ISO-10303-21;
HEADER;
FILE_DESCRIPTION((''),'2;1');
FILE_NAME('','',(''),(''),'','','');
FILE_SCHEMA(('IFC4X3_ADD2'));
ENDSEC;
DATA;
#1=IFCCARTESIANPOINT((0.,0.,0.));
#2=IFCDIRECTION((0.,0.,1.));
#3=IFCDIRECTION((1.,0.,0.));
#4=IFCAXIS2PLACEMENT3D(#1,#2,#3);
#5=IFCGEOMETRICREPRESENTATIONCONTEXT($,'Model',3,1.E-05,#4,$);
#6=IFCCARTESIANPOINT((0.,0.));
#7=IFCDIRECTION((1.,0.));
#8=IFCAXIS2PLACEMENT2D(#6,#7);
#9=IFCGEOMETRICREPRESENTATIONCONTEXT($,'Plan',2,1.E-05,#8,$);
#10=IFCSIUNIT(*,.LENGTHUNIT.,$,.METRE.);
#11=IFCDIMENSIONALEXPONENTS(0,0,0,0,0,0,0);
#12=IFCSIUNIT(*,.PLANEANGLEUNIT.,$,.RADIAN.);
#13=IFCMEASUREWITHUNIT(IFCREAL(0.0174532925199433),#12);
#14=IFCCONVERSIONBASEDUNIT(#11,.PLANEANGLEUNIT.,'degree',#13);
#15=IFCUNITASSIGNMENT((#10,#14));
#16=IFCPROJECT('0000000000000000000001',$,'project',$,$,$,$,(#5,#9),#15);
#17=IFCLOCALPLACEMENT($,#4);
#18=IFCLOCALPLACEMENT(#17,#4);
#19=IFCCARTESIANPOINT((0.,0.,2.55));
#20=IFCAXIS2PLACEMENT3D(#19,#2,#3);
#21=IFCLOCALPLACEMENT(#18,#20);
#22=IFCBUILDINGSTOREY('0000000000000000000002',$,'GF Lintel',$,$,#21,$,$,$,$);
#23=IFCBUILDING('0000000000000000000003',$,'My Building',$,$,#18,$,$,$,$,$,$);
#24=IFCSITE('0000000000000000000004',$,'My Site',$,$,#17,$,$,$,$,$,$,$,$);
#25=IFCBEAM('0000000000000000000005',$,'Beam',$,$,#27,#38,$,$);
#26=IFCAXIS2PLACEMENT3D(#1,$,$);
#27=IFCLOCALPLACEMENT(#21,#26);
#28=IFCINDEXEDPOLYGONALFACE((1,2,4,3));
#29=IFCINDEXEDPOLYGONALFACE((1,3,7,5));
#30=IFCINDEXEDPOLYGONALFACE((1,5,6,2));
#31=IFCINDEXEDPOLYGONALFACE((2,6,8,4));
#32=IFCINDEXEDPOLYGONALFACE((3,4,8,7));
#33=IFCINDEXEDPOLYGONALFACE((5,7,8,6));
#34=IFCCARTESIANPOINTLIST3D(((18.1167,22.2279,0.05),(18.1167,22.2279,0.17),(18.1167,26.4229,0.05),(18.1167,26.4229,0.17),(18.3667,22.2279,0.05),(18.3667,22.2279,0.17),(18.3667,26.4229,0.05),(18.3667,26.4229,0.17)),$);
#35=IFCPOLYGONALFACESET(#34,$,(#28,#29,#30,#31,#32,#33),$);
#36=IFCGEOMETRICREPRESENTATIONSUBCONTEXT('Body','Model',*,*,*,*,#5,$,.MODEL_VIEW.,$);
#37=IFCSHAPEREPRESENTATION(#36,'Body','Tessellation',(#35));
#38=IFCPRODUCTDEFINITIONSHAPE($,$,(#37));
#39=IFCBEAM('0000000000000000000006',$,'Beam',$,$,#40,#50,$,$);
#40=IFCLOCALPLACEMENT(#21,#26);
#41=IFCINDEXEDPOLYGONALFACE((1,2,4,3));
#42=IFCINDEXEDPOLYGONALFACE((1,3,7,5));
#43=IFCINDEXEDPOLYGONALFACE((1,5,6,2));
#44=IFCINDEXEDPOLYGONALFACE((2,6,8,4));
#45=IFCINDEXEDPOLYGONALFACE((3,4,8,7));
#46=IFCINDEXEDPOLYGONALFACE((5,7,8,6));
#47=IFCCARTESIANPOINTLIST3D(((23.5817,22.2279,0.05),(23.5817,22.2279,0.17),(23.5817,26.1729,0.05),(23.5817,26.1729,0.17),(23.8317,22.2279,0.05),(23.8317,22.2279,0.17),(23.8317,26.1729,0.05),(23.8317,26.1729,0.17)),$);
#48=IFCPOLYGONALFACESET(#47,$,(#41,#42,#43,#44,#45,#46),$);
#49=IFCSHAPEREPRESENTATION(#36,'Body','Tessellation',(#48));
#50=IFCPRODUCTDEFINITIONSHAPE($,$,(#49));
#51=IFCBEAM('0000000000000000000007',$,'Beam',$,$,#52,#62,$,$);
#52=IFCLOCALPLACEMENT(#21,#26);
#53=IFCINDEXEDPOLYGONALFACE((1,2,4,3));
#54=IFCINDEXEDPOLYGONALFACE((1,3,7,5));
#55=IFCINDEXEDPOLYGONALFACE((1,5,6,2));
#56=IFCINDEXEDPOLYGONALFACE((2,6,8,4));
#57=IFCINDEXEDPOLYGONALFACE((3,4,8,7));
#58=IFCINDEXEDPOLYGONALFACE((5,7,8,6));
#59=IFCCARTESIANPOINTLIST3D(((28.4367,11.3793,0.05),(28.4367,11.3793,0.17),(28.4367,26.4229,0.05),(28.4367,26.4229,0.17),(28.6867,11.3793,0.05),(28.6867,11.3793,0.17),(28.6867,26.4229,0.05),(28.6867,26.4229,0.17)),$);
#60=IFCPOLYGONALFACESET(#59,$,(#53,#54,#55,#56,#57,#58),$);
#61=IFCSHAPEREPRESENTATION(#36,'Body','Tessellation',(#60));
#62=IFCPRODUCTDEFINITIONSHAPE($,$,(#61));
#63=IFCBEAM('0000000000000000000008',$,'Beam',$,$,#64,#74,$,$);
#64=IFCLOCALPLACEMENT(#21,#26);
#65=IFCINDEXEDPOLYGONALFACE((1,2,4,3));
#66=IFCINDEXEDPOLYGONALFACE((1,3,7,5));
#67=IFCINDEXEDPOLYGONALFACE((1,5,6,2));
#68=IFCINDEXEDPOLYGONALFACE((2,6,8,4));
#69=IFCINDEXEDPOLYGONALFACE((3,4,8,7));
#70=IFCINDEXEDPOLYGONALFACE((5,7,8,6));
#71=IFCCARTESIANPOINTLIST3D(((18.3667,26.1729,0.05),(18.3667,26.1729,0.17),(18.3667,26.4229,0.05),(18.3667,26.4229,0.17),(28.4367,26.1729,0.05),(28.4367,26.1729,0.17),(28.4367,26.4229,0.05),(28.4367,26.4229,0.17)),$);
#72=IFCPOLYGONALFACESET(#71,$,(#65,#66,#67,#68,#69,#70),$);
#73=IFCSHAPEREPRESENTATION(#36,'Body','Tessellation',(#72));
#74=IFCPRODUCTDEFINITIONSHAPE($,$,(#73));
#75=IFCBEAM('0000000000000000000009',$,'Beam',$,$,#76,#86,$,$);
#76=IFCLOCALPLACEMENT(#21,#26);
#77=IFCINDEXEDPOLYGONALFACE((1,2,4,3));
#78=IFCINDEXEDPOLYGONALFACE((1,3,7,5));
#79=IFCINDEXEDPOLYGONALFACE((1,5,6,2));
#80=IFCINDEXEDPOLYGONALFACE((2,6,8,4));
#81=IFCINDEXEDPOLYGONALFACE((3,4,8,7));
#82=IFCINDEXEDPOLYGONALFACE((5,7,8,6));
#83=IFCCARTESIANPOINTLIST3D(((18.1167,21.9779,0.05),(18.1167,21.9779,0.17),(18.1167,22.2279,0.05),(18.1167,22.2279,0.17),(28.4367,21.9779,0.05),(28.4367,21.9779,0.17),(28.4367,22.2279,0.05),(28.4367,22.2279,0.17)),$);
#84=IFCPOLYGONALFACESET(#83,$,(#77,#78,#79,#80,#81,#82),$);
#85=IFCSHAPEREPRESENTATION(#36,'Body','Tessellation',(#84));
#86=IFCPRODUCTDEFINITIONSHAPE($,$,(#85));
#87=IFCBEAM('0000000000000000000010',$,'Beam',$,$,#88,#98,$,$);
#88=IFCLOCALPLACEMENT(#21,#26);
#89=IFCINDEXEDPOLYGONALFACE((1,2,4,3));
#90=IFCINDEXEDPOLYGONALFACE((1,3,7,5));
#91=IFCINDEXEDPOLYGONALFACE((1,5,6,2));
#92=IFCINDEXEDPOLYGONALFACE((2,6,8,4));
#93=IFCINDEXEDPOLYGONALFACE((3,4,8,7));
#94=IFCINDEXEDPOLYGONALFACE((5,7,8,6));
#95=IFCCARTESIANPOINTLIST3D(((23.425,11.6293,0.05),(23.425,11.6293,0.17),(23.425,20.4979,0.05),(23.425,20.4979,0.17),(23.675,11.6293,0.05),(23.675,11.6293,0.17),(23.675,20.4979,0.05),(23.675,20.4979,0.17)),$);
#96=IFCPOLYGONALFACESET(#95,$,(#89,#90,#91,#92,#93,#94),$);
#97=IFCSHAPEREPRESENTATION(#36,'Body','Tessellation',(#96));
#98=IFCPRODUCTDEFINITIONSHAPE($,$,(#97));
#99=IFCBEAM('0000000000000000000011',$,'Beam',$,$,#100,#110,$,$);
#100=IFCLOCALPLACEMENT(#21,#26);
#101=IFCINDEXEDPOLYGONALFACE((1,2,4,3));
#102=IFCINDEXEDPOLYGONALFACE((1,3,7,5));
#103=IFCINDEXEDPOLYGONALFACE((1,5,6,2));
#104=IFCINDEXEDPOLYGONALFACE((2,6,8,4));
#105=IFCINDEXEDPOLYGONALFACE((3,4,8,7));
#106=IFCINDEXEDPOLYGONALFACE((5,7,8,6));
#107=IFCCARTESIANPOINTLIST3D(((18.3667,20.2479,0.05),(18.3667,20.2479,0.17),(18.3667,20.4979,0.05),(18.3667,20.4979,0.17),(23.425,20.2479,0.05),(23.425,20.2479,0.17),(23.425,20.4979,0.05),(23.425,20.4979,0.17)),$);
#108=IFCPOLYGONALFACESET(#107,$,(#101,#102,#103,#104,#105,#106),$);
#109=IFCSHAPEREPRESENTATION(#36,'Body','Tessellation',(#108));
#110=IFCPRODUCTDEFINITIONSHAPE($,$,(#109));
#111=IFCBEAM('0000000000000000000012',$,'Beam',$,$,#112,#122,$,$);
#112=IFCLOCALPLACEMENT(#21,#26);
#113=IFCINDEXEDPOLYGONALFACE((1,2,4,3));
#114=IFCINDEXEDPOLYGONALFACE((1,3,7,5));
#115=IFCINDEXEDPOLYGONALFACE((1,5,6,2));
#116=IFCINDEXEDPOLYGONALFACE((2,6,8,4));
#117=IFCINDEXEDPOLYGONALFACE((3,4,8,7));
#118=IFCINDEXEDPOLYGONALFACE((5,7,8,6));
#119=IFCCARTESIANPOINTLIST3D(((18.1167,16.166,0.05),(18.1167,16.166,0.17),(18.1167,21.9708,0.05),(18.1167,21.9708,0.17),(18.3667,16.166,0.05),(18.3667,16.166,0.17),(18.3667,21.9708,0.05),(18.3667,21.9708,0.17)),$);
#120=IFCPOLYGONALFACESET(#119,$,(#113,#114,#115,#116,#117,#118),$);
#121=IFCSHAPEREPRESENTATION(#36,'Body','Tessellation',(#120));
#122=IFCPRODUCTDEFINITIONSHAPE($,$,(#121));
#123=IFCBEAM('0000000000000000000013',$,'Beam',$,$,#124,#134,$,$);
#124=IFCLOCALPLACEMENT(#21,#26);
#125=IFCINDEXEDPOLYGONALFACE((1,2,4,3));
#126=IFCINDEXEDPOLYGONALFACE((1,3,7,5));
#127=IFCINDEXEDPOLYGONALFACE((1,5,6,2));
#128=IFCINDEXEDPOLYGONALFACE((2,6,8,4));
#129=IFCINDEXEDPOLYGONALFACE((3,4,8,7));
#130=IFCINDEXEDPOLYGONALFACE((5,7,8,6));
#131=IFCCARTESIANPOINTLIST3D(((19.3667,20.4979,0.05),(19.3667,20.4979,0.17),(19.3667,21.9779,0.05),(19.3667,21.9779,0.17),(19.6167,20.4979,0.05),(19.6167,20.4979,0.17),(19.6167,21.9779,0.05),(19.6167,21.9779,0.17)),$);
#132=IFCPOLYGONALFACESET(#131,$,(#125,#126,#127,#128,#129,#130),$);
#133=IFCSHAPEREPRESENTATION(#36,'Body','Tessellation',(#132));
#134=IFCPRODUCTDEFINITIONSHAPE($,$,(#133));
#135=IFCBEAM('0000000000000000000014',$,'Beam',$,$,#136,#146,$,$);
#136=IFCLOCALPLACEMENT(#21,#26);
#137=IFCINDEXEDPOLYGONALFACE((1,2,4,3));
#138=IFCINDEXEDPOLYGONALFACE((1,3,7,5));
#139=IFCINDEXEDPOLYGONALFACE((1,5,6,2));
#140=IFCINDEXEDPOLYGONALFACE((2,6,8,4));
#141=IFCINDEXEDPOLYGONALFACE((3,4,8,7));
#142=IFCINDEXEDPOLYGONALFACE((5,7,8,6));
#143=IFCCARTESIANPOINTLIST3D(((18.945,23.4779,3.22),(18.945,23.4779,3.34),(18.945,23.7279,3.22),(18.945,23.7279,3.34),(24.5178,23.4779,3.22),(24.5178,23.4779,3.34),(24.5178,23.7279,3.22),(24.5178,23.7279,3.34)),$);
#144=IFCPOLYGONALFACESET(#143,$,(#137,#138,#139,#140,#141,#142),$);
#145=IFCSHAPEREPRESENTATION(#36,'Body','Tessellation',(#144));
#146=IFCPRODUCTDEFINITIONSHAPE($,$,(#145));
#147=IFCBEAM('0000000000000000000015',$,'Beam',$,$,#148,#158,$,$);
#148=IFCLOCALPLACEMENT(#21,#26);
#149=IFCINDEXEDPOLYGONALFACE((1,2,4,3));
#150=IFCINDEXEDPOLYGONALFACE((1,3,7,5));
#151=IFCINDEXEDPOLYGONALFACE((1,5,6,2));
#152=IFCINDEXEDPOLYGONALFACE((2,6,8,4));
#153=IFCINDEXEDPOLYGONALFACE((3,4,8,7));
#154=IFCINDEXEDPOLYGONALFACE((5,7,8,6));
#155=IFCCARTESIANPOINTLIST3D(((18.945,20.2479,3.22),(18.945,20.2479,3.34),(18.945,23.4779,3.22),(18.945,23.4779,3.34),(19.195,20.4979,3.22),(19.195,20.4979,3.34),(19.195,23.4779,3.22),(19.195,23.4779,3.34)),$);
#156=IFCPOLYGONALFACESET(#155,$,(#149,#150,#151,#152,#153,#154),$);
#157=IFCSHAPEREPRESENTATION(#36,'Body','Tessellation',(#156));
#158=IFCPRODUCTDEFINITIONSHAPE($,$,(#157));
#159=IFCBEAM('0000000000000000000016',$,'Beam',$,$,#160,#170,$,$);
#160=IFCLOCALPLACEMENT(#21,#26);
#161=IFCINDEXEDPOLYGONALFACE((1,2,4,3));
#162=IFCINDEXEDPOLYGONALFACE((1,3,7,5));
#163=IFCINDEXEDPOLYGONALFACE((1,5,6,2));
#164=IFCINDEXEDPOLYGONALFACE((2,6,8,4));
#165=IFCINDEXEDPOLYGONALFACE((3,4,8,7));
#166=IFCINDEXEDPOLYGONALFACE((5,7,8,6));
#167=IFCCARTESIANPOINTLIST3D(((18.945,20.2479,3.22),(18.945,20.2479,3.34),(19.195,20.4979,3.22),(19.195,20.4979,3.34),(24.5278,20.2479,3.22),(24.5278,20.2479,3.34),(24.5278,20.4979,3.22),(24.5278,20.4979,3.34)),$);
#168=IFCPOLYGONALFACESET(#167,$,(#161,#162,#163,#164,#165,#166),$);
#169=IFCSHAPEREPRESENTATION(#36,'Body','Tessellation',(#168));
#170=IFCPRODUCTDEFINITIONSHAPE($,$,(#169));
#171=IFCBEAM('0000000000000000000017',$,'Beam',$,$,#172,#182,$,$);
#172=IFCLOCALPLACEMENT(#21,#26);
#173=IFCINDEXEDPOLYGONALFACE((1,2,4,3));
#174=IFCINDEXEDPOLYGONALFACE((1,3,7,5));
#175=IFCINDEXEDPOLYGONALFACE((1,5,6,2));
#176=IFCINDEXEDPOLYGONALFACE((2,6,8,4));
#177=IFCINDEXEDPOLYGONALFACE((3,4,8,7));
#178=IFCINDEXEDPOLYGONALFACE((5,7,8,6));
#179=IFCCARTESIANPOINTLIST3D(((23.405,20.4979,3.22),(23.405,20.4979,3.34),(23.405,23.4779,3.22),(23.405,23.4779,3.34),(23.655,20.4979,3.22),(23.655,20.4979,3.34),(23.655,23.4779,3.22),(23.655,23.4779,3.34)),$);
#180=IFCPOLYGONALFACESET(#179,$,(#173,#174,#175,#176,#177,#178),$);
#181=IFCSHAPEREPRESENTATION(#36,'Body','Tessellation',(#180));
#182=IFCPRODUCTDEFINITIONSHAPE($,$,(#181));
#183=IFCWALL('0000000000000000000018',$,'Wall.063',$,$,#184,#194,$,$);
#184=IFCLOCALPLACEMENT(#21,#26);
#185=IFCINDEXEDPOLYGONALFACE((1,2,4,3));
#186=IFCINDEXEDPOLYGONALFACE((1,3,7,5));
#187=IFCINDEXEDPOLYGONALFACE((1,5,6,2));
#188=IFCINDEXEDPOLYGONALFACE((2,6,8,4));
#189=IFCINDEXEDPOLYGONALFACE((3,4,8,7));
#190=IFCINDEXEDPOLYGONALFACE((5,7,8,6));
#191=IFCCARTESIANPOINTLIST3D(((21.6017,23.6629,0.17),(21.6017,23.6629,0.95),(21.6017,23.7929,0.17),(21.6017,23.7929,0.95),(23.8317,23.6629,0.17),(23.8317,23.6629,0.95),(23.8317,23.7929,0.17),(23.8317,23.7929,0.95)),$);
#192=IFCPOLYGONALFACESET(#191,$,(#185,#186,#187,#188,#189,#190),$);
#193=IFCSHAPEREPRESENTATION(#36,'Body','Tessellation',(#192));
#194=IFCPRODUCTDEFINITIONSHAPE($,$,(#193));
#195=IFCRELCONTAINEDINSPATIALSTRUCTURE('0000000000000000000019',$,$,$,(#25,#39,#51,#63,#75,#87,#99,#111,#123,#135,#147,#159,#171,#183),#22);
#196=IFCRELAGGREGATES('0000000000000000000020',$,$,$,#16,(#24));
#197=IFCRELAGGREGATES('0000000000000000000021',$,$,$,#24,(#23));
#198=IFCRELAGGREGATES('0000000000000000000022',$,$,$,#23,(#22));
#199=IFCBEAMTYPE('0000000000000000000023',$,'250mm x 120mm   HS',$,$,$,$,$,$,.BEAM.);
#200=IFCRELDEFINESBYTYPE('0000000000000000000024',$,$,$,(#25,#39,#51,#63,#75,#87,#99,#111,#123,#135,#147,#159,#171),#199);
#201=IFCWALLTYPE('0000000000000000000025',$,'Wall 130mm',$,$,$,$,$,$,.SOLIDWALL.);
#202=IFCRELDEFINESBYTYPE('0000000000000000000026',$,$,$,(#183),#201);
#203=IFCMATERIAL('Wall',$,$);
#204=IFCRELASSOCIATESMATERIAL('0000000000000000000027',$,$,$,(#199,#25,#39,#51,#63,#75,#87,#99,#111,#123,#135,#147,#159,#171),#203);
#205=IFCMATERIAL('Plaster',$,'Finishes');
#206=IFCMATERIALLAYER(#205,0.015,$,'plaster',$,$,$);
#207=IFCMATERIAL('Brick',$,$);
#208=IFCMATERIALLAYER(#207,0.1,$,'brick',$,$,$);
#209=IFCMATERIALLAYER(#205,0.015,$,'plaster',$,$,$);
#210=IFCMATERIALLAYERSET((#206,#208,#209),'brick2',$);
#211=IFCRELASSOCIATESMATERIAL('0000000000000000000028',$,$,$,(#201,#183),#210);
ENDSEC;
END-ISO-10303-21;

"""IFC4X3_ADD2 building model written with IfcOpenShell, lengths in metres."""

from ifc_helpers import new_model, entity, si_unit, converted_unit, frame, origin_with_axes, origin_2d_with_axis, place, context, subcontext, project, spatial, line, indexed_curve, rectangle, outline, extrude, clip, halfspace, material, layer, layer_set, layer_usage, material_profile, profile_set, profile_usage, type_object, element, save


model = new_model("IFC4X3_ADD2")

# Units and contexts
model_context = context("Model", 3, precision=1e-05, world=origin_with_axes())
plan_context = context("Plan", 2, precision=1e-05, world=origin_2d_with_axis())
body_context = subcontext(model_context, "Body", "Model", "MODEL_VIEW")
ifc_project = project(units=[si_unit("LENGTHUNIT", "METRE"), converted_unit("PLANEANGLEUNIT", "degree", entity("IfcReal", 0.0174532925199433), si_unit("PLANEANGLEUNIT", "RADIAN"), dimensions=[0, 0, 0, 0, 0, 0, 0])], contexts=[model_context, plan_context])

# Site, building, storey
site_placement = place(None, origin_with_axes())
site = spatial("IfcSite", under=ifc_project, at=site_placement, Name="My Site")
building_placement = place(site_placement, origin_with_axes())
building = spatial("IfcBuilding", under=site, at=building_placement, Name="My Building")
storey_placement = place(building_placement, frame((0.0, 0.0, 2.55), z_axis=(0.0, 0.0, 1.0), x_axis=(1.0, 0.0, 0.0)))
storey = spatial("IfcBuildingStorey", under=building, at=storey_placement, Name="GF Lintel")

# Beams
ifc_material_1 = material(Name="Wall")
ifc_material_profile = material_profile(ifc_material_1, rectangle(XDim=0.25, YDim=0.12))
ifc_profile_set = profile_set([ifc_material_profile], Name="concrete")
ifc_profile_usage_1 = profile_usage(ifc_profile_set, cardinal=5)
beam_type = type_object("IfcBeamType", Name="250mm x 120mm   HS", PredefinedType="BEAM", material=ifc_profile_set)
beam_1_placement = place(storey_placement, frame((18.2417, 26.4229, 0.11), z_axis=(0.0, -1.0, 0.0), x_axis=(1.0, 0.0, 0.0)))
element("IfcBeam", 1, at=beam_1_placement, inside=storey, type_object=beam_type, material=ifc_profile_usage_1, Name="Beam", context=body_context, shape_type="SweptSolid", body=[
    extrude(rectangle(XDim=0.25, YDim=0.12), origin_with_axes(), (0.0, 0.0, 1.0), 4.195),
])
ifc_profile_usage_2 = profile_usage(ifc_profile_set, cardinal=5)
beam_2_placement = place(storey_placement, frame((23.7067, 26.1729, 0.11), z_axis=(0.0, -1.0, 0.0), x_axis=(1.0, 0.0, 0.0)))
element("IfcBeam", 2, at=beam_2_placement, inside=storey, type_object=beam_type, material=ifc_profile_usage_2, Name="Beam", context=body_context, shape_type="SweptSolid", body=[
    extrude(rectangle(XDim=0.25, YDim=0.12), origin_with_axes(), (0.0, 0.0, 1.0), 3.945),
])
ifc_profile_usage_3 = profile_usage(ifc_profile_set, cardinal=5)
beam_3_placement = place(storey_placement, frame((28.5617, 26.4229, 0.11), z_axis=(0.0, -1.0, 0.0), x_axis=(1.0, 0.0, 0.0)))
element("IfcBeam", 3, at=beam_3_placement, inside=storey, type_object=beam_type, material=ifc_profile_usage_3, Name="Beam", context=body_context, shape_type="SweptSolid", body=[
    extrude(rectangle(XDim=0.25, YDim=0.12), origin_with_axes(), (0.0, 0.0, 1.0), 15.0436),
])
ifc_profile_usage_4 = profile_usage(ifc_profile_set, cardinal=5)
beam_4_placement = place(storey_placement, frame((18.3667, 26.2979, 0.11), z_axis=(1.0, 0.0, 0.0), x_axis=(0.0, 1.0, 0.0)))
element("IfcBeam", 4, at=beam_4_placement, inside=storey, type_object=beam_type, material=ifc_profile_usage_4, Name="Beam", context=body_context, shape_type="SweptSolid", body=[
    extrude(rectangle(XDim=0.25, YDim=0.12), origin_with_axes(), (0.0, 0.0, 1.0), 10.07),
])
ifc_profile_usage_5 = profile_usage(ifc_profile_set, cardinal=5)
beam_5_placement = place(storey_placement, frame((18.1167, 22.1029, 0.11), z_axis=(1.0, 0.0, 0.0), x_axis=(0.0, 1.0, 0.0)))
element("IfcBeam", 5, at=beam_5_placement, inside=storey, type_object=beam_type, material=ifc_profile_usage_5, Name="Beam", context=body_context, shape_type="SweptSolid", body=[
    extrude(rectangle(XDim=0.25, YDim=0.12), origin_with_axes(), (0.0, 0.0, 1.0), 10.32),
])
ifc_profile_usage_6 = profile_usage(ifc_profile_set, cardinal=5)
beam_6_placement = place(storey_placement, frame((23.55, 20.4979, 0.11), z_axis=(0.0, -1.0, 0.0), x_axis=(1.0, 0.0, 0.0)))
element("IfcBeam", 6, at=beam_6_placement, inside=storey, type_object=beam_type, material=ifc_profile_usage_6, Name="Beam", context=body_context, shape_type="SweptSolid", body=[
    extrude(rectangle(XDim=0.25, YDim=0.12), origin_with_axes(), (0.0, 0.0, 1.0), 8.8685),
])
ifc_profile_usage_7 = profile_usage(ifc_profile_set, cardinal=5)
beam_7_placement = place(storey_placement, frame((18.3667, 20.3729, 0.11), z_axis=(1.0, 0.0, 0.0), x_axis=(0.0, 1.0, 0.0)))
element("IfcBeam", 7, at=beam_7_placement, inside=storey, type_object=beam_type, material=ifc_profile_usage_7, Name="Beam", context=body_context, shape_type="SweptSolid", body=[
    extrude(rectangle(XDim=0.25, YDim=0.12), origin_with_axes(), (0.0, 0.0, 1.0), 5.0583),
])
ifc_profile_usage_8 = profile_usage(ifc_profile_set, cardinal=5)
beam_8_placement = place(storey_placement, frame((18.2417, 21.9708, 0.11), z_axis=(0.0, -1.0, 0.0), x_axis=(1.0, 0.0, 0.0)))
element("IfcBeam", 8, at=beam_8_placement, inside=storey, type_object=beam_type, material=ifc_profile_usage_8, Name="Beam", context=body_context, shape_type="SweptSolid", body=[
    extrude(rectangle(XDim=0.25, YDim=0.12), origin_with_axes(), (0.0, 0.0, 1.0), 5.8048),
])
ifc_profile_usage_9 = profile_usage(ifc_profile_set, cardinal=5)
beam_9_placement = place(storey_placement, frame((19.4917, 21.9779, 0.11), z_axis=(0.0, -1.0, 0.0), x_axis=(1.0, 0.0, 0.0)))
element("IfcBeam", 9, at=beam_9_placement, inside=storey, type_object=beam_type, material=ifc_profile_usage_9, Name="Beam", context=body_context, shape_type="SweptSolid", body=[
    extrude(rectangle(XDim=0.25, YDim=0.12), origin_with_axes(), (0.0, 0.0, 1.0), 1.48),
])
ifc_profile_usage_10 = profile_usage(ifc_profile_set, cardinal=5)
beam_10_placement = place(storey_placement, frame((18.945, 23.6029, 3.28), z_axis=(1.0, 0.0, 0.0), x_axis=(0.0, 1.0, 0.0)))
element("IfcBeam", 10, at=beam_10_placement, inside=storey, type_object=beam_type, material=ifc_profile_usage_10, Name="Beam", context=body_context, shape_type="SweptSolid", body=[
    extrude(rectangle(XDim=0.25, YDim=0.12), origin_with_axes(), (0.0, 0.0, 1.0), 5.5728),
])
ifc_profile_usage_11 = profile_usage(ifc_profile_set, cardinal=5)
beam_11_placement = place(storey_placement, frame((19.07, 20.2479, 3.28), z_axis=(0.0, 1.0, 0.0), x_axis=(-1.0, 0.0, 0.0)))
element("IfcBeam", 11, at=beam_11_placement, inside=storey, type_object=beam_type, material=ifc_profile_usage_11, Name="Beam", context=body_context, shape_type="Clipping", body=[
    clip(extrude(rectangle(XDim=0.25, YDim=0.12), origin_with_axes(), (0.0, 0.0, 1.0), 3.23), halfspace(frame((0.125, -5.83, 0.0), z_axis=(-0.707107, 0.0, -0.707107), x_axis=(0.0, 1.0, 0.0)), False)),
])
ifc_profile_usage_12 = profile_usage(ifc_profile_set, cardinal=5)
beam_12_placement = place(storey_placement, frame((18.945, 20.3729, 3.28), z_axis=(1.0, 0.0, 0.0), x_axis=(0.0, 1.0, 0.0)))
element("IfcBeam", 12, at=beam_12_placement, inside=storey, type_object=beam_type, material=ifc_profile_usage_12, Name="Beam", context=body_context, shape_type="Clipping", body=[
    clip(extrude(rectangle(XDim=0.25, YDim=0.12), origin_with_axes(), (0.0, 0.0, 1.0), 5.5828), halfspace(frame((-0.125, -5.83, 0.0), z_axis=(0.707107, 0.0, -0.707107), x_axis=(0.0, -1.0, 0.0)), False)),
])
ifc_profile_usage_13 = profile_usage(ifc_profile_set, cardinal=5)
beam_13_placement = place(storey_placement, frame((23.53, 20.4979, 3.28), z_axis=(0.0, 1.0, 0.0), x_axis=(-1.0, 0.0, 0.0)))
element("IfcBeam", 13, at=beam_13_placement, inside=storey, type_object=beam_type, material=ifc_profile_usage_13, Name="Beam", context=body_context, shape_type="SweptSolid", body=[
    extrude(rectangle(XDim=0.25, YDim=0.12), origin_with_axes(), (0.0, 0.0, 1.0), 2.98),
])

# Wall
ifc_material_2 = material(Name="Plaster", Category="Finishes")
ifc_layer_1 = layer(ifc_material_2, 0.015, Name="plaster")
ifc_material_3 = material(Name="Brick")
ifc_layer_2 = layer(ifc_material_3, 0.1, Name="brick")
ifc_layer_3 = layer(ifc_material_2, 0.015, Name="plaster")
ifc_layer_set_1 = layer_set([ifc_layer_1, ifc_layer_2, ifc_layer_3], Name="brick2")
ifc_layer_usage_1 = layer_usage(ifc_layer_set_1, "AXIS2", "POSITIVE", 0.0)
wall_type_1 = type_object("IfcWallType", Name="Wall 130mm", PredefinedType="SOLIDWALL", material=ifc_layer_set_1)
wall_1_placement = place(storey_placement, frame((21.6017, 23.6629, 0.17), z_axis=(0.0, 0.0, 1.0), x_axis=(1.0, 0.0, 0.0)))
element("IfcWall", 14, at=wall_1_placement, inside=storey, type_object=wall_type_1, material=ifc_layer_usage_1, Name="Wall.063", context=body_context, shape_type="SweptSolid", body=[
    extrude(outline(indexed_curve([(0.0, 0.0), (0.0, 0.13), (2.23, 0.13), (2.23, 0.0)], segments=[line(1, 2, 3, 4, 1)])), origin_with_axes(), (0.0, 0.0, 1.0), 0.78),
])

save(model, "model.ifc")
